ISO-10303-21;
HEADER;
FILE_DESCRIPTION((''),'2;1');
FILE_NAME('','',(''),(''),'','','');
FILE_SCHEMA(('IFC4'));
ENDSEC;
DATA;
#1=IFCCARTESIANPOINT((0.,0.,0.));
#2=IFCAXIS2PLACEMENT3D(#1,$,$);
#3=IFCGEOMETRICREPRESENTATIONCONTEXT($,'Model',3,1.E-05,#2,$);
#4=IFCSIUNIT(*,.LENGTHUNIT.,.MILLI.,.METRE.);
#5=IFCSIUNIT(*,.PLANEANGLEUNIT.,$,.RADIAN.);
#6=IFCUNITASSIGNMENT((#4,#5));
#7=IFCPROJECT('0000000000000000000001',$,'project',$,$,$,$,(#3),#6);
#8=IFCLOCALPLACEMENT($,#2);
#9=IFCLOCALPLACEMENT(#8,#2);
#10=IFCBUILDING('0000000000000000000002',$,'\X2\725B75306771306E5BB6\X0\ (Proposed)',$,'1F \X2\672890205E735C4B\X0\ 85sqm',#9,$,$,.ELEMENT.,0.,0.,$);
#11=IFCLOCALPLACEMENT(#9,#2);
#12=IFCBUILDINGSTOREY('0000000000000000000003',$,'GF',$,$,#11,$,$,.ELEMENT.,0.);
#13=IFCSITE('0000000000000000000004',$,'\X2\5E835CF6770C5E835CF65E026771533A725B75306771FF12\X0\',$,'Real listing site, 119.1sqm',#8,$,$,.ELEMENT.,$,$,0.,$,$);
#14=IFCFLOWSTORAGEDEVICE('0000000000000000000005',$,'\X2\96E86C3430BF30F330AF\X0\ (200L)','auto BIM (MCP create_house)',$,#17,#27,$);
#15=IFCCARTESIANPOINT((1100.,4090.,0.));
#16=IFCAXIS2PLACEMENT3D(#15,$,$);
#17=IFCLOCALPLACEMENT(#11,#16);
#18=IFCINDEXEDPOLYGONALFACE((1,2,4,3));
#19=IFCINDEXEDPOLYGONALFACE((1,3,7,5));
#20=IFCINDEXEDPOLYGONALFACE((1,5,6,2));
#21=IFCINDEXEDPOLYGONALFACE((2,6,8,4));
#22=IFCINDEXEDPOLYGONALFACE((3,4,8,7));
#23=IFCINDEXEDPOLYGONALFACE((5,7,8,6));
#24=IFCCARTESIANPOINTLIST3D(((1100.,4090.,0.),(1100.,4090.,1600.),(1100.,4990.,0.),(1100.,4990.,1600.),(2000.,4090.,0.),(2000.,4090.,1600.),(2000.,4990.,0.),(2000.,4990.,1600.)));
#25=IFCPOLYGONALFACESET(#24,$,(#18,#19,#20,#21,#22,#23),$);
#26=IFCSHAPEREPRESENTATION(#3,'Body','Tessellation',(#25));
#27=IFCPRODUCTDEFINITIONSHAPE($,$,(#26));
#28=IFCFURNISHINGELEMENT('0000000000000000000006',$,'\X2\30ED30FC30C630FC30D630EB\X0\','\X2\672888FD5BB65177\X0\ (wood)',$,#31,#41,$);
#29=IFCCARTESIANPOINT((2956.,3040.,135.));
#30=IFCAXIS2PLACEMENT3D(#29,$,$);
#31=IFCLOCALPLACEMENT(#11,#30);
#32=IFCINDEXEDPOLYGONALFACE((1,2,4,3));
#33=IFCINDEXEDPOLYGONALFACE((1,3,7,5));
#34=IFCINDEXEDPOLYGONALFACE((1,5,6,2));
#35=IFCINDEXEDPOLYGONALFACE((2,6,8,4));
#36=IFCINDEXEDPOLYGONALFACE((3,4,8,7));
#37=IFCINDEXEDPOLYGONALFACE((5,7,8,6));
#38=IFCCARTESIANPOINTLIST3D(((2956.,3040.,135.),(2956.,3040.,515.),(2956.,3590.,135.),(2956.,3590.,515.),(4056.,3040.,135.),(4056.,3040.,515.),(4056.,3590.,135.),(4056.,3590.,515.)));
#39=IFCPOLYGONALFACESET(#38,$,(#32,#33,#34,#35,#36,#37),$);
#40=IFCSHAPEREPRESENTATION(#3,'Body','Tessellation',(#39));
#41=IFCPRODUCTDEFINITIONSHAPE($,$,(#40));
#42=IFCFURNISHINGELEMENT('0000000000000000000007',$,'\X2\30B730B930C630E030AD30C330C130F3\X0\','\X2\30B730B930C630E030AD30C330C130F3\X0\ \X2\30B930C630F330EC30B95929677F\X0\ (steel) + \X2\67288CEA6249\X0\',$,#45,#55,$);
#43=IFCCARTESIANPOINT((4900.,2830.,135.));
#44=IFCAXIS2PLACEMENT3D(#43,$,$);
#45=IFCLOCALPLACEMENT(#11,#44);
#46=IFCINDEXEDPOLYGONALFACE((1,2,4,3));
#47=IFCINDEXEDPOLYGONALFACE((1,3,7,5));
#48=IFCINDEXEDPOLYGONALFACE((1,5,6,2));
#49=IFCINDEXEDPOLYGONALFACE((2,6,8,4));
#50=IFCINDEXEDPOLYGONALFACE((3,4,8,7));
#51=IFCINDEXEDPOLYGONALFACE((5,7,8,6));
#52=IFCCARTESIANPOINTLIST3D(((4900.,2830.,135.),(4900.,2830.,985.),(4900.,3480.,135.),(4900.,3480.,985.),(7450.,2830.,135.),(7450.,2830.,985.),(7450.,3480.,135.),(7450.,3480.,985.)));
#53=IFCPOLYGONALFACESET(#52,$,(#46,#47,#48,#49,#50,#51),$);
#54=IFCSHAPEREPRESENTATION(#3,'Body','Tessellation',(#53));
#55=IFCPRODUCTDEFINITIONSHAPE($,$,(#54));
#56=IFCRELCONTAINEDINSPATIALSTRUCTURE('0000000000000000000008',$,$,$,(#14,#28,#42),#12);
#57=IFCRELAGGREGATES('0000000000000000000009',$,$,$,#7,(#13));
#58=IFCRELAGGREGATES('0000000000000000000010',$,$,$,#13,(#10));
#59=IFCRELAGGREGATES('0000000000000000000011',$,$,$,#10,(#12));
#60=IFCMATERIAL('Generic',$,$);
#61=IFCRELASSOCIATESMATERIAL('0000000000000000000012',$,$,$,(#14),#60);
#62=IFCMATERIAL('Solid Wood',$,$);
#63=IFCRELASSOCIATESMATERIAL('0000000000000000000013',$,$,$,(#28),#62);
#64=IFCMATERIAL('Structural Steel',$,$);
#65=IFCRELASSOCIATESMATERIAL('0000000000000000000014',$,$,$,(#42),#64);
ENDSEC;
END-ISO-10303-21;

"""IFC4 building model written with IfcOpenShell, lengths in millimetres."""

from ifc_helpers import new_model, si_unit, frame, frame_2d, origin, place, context, project, spatial, rectangle, extrude, material, element, save


model = new_model("IFC4")

# Units and contexts
model_context = context("Model", 3, precision=1e-05, world=origin())
ifc_project = project(units=[si_unit("LENGTHUNIT", "METRE", prefix="MILLI"), si_unit("PLANEANGLEUNIT", "RADIAN")], contexts=[model_context])

# Site, building, storey
site_placement = place(None, origin())
site = spatial("IfcSite", under=ifc_project, at=site_placement, Name="広島県広島市東区牛田東２", ObjectType="Real listing site, 119.1sqm", CompositionType="ELEMENT", RefElevation=0.0)
building_placement = place(site_placement, origin())
building = spatial("IfcBuilding", under=site, at=building_placement, Name="牛田東の家 (Proposed)", ObjectType="1F 木造平屋 85sqm", CompositionType="ELEMENT", ElevationOfRefHeight=0.0, ElevationOfTerrain=0.0)
storey_placement = place(building_placement, origin())
storey = spatial("IfcBuildingStorey", under=building, at=storey_placement, Name="GF", CompositionType="ELEMENT", Elevation=0.0)

# Shared definitions
ifc_material_1 = material(Name="Solid Wood")

# Shared definitions
ifc_material_2 = material(Name="Generic")

# Flow storage device
flow_storage_device_placement = place(storey_placement, frame((1100.0, 4090.0, 0.0)))
element("IfcFlowStorageDevice", 1, at=flow_storage_device_placement, inside=storey, material=ifc_material_2, Name="雨水タンク (200L)", Description="auto BIM (MCP create_house)", context=model_context, shape_type="SweptSolid", body=[
    extrude(rectangle(XDim=900.0, YDim=900.0, at=frame_2d((450.0, 450.0))), frame((1100.0, 4090.0, 0.0)), (0.0, 0.0, 1.0), 1600.0),
])

# Furnishing elements
furnishing_1_placement = place(storey_placement, frame((2956.0, 3040.0, 135.0)))
element("IfcFurnishingElement", 2, at=furnishing_1_placement, inside=storey, material=ifc_material_1, Name="ローテーブル", Description="木製家具 (wood)", context=model_context, shape_type="SweptSolid", body=[
    extrude(rectangle(XDim=1100.0, YDim=550.0, at=frame_2d((550.0, 275.0))), frame((2956.0, 3040.0, 135.0)), (0.0, 0.0, 1.0), 380.0),
])
ifc_material_3 = material(Name="Structural Steel")
furnishing_2_placement = place(storey_placement, frame((4900.0, 2830.0, 135.0)))
element("IfcFurnishingElement", 3, at=furnishing_2_placement, inside=storey, material=ifc_material_3, Name="システムキッチン", Description="システムキッチン ステンレス天板 (steel) + 木質扉", context=model_context, shape_type="SweptSolid", body=[
    extrude(rectangle(XDim=2550.0, YDim=650.0, at=frame_2d((1275.0, 325.0))), frame((4900.0, 2830.0, 135.0)), (0.0, 0.0, 1.0), 850.0),
])

save(model, "model.ifc")
